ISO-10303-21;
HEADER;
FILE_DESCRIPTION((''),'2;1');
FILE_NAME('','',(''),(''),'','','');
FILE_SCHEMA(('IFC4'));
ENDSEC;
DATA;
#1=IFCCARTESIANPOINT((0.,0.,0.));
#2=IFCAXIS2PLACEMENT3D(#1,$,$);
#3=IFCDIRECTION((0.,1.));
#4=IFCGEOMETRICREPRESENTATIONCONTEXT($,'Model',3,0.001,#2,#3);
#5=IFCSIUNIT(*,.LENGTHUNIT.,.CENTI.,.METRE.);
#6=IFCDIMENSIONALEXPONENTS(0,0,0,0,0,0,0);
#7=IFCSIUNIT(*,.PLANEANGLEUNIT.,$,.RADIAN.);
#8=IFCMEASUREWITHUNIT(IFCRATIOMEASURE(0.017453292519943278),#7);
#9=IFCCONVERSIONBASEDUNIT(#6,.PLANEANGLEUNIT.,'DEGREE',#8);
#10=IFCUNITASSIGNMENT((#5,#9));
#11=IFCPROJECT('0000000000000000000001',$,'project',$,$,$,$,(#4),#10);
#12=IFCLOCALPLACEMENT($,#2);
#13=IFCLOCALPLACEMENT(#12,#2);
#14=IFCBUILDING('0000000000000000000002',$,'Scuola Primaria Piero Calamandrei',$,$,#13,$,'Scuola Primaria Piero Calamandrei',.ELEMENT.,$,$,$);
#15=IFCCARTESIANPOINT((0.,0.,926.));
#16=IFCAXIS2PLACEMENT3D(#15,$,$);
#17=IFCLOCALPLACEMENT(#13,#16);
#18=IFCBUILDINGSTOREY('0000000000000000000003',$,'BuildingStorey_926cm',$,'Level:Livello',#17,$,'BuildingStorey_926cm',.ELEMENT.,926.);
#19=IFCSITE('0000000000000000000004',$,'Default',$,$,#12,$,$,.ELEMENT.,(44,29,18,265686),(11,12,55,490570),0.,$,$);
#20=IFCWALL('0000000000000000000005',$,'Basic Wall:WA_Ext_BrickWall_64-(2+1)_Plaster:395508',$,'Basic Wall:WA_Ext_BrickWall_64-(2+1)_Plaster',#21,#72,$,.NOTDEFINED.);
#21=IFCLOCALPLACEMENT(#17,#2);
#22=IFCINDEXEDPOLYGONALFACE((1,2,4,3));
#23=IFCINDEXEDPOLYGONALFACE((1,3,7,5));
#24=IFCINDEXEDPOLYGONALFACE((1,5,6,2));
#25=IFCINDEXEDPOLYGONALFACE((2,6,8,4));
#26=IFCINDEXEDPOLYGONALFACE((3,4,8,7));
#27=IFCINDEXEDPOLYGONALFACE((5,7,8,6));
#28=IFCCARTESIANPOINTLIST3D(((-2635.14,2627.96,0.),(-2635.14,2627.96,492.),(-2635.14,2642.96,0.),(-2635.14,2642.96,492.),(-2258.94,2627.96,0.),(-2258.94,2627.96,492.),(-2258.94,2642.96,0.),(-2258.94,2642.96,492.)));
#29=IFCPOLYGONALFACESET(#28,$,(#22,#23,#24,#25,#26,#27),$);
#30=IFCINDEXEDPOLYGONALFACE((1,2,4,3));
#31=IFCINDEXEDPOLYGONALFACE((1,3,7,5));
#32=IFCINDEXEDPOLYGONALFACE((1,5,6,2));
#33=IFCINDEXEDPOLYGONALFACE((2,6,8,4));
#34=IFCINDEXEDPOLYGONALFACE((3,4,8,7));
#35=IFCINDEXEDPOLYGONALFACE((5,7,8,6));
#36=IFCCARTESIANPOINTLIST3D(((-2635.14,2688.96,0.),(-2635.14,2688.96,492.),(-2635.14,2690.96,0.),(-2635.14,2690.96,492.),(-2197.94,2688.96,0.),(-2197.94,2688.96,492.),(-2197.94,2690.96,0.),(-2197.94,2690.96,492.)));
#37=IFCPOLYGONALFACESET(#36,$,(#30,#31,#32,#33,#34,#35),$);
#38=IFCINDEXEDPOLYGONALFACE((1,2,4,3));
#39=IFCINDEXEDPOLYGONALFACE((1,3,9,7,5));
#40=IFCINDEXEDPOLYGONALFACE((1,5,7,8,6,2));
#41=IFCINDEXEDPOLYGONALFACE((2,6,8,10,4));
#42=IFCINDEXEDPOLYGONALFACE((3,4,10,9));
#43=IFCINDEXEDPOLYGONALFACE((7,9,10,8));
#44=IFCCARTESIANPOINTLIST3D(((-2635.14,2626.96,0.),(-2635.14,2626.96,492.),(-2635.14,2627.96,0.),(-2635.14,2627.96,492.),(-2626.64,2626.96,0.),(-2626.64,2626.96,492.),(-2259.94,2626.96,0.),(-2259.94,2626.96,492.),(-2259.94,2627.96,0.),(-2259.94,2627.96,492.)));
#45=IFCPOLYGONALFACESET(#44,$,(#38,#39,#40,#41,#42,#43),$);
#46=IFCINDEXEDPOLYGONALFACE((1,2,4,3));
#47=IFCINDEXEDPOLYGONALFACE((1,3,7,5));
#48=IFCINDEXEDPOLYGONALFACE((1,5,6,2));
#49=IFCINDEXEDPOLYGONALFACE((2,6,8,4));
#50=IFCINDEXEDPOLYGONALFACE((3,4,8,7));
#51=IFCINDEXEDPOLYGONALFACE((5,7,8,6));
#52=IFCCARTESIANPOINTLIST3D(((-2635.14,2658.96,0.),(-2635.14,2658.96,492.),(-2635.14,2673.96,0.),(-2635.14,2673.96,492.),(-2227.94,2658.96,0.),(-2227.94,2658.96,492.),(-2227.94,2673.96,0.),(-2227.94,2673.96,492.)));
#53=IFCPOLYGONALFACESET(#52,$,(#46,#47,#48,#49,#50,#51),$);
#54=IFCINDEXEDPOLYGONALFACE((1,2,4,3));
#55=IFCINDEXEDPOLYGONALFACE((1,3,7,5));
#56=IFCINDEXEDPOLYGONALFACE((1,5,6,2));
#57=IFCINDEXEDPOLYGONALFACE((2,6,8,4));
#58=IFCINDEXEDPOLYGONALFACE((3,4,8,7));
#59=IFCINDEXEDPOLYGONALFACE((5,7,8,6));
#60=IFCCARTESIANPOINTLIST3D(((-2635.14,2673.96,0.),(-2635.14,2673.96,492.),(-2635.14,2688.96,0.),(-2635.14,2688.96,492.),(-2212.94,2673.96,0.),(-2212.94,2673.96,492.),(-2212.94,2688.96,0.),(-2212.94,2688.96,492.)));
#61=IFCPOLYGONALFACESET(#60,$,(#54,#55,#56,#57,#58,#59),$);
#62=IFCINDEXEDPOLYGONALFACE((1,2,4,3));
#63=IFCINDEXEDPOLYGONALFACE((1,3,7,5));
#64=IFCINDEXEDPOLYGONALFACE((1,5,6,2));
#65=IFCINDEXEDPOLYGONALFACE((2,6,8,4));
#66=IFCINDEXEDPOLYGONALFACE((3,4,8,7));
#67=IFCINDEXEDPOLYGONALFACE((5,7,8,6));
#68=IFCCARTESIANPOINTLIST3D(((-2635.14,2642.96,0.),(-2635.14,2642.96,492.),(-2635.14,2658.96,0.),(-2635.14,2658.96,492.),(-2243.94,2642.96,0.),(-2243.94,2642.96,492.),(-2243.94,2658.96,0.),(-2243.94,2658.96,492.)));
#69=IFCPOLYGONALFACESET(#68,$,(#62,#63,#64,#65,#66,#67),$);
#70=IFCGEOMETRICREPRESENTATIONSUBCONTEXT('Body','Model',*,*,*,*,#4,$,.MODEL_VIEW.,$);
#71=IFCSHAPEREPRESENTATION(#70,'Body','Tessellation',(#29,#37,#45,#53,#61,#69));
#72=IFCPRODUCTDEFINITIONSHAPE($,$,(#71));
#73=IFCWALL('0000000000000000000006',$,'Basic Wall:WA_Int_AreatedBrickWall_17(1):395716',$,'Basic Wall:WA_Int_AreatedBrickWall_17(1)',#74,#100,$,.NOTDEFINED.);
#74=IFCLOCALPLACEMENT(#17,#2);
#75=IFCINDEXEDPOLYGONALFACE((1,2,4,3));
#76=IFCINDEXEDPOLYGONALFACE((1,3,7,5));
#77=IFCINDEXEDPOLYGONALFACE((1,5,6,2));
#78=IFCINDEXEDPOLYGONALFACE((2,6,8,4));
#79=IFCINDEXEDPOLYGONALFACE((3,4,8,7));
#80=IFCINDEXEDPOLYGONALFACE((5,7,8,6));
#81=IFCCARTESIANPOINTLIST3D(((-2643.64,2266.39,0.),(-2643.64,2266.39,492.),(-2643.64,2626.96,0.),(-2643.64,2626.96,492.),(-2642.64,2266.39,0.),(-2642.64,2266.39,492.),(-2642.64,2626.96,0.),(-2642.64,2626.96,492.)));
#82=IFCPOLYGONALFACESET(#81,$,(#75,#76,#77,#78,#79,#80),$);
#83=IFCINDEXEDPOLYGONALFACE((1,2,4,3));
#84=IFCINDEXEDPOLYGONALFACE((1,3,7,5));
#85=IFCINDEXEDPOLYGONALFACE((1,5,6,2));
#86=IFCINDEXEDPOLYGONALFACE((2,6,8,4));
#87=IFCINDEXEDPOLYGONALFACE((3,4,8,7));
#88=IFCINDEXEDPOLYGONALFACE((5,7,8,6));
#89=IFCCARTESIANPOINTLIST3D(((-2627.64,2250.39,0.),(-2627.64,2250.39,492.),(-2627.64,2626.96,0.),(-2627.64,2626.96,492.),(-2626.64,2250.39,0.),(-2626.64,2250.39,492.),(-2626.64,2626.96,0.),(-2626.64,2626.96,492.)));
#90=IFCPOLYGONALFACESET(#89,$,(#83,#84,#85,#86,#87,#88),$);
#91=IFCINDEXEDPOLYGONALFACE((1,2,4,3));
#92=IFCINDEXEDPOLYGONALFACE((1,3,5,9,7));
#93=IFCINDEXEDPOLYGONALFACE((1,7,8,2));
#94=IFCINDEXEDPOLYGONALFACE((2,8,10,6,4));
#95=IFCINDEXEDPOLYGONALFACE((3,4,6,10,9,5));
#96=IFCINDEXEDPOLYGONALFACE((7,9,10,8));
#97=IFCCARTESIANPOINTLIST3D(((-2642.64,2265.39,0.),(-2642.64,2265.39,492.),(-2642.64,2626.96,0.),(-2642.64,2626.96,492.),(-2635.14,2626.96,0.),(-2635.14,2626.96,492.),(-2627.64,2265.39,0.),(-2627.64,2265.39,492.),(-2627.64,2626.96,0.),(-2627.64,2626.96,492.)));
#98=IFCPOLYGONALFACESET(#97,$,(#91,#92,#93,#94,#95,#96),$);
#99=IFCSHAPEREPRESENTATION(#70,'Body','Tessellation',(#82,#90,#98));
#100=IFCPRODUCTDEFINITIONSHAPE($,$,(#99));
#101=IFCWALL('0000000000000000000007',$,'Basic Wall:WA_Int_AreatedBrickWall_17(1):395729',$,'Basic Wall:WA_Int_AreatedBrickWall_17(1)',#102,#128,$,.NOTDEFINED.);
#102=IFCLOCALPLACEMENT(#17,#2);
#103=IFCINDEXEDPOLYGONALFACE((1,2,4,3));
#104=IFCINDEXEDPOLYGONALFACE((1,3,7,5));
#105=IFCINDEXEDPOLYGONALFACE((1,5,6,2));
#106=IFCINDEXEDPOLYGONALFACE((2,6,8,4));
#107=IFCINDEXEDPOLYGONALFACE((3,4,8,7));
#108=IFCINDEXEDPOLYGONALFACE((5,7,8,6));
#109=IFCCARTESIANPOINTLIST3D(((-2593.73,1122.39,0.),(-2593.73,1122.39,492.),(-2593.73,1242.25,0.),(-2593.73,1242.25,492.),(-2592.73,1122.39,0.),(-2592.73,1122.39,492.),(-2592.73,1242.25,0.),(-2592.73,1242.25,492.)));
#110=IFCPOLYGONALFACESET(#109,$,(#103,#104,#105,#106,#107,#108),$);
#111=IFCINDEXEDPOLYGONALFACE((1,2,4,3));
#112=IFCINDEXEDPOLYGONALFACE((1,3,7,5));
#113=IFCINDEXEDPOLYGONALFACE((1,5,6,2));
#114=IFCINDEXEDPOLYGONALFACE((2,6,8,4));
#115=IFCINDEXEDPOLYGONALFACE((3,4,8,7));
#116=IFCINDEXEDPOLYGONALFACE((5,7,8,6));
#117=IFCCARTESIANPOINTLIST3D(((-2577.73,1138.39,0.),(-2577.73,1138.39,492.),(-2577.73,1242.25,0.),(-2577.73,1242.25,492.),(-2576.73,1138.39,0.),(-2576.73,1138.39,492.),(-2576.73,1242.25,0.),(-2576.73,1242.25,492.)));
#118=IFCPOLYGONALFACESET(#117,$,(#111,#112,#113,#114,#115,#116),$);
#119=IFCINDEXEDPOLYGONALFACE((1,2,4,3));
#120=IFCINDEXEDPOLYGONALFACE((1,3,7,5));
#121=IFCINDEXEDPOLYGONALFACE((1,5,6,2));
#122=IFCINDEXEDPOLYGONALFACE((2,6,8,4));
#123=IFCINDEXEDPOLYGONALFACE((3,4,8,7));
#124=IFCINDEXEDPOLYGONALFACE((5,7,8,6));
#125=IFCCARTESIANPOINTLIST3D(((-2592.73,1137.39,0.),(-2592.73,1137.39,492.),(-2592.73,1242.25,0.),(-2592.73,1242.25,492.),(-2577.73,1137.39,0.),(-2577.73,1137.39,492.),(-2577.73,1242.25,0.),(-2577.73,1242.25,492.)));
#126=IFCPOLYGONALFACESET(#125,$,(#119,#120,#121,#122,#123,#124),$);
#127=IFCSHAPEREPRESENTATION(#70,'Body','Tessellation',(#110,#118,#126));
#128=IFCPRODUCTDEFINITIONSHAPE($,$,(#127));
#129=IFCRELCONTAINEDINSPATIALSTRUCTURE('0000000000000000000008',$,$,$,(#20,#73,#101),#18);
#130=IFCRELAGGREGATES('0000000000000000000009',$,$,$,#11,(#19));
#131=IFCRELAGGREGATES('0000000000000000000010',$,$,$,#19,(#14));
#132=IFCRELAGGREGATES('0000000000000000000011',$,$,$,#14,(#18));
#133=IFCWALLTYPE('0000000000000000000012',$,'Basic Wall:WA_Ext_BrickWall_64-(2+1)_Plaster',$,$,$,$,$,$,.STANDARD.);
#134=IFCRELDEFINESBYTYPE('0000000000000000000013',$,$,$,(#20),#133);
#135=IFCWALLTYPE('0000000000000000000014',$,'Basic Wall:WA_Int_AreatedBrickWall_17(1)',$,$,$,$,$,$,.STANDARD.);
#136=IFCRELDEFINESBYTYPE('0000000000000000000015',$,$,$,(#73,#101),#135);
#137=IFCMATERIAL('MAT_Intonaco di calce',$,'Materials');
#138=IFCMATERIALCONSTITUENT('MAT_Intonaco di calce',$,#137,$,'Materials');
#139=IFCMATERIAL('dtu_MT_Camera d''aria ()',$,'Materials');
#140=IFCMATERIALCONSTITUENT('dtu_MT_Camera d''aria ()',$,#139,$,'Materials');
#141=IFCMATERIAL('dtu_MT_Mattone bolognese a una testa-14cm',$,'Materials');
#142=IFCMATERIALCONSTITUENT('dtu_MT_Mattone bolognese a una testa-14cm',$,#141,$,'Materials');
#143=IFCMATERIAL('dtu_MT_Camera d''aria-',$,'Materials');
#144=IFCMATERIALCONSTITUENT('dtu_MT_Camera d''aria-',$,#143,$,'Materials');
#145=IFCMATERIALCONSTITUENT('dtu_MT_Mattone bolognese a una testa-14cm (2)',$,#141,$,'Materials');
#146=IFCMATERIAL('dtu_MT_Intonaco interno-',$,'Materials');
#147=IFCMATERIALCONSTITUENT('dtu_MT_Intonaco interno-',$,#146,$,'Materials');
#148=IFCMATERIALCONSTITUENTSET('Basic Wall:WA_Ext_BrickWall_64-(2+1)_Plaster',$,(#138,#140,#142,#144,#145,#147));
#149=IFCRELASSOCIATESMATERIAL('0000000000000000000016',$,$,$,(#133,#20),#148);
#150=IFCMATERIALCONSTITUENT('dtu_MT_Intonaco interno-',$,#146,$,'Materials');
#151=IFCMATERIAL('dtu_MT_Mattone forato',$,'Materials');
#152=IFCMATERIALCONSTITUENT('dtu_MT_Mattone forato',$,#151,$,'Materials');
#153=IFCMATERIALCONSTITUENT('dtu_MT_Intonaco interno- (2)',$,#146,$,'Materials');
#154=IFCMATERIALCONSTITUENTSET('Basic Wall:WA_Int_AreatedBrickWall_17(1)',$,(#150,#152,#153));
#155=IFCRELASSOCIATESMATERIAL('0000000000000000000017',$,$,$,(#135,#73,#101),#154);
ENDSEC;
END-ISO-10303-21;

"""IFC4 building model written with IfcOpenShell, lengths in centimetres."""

from ifc_helpers import new_model, entity, si_unit, converted_unit, direction, frame, origin, place, context, subcontext, project, spatial, indexed_curve, outline, extrude, material, constituent, constituent_set, type_object, element, save


model = new_model("IFC4")

# Units and contexts
model_context = context("Model", 3, precision=0.001, world=origin(), true_north=direction((0.0, 1.0)))
body_context = subcontext(model_context, "Body", "Model", "MODEL_VIEW")
ifc_project = project(units=[si_unit("LENGTHUNIT", "METRE", prefix="CENTI"), converted_unit("PLANEANGLEUNIT", "DEGREE", entity("IfcRatioMeasure", 0.017453292519943278), si_unit("PLANEANGLEUNIT", "RADIAN"), dimensions=[0, 0, 0, 0, 0, 0, 0])], contexts=[model_context])

# Site, building, storey
site_placement = place(None, origin())
site = spatial("IfcSite", under=ifc_project, at=site_placement, Name="Default", CompositionType="ELEMENT", RefLatitude=(44, 29, 18, 265686), RefLongitude=(11, 12, 55, 490570), RefElevation=0.0)
building_placement = place(site_placement, origin())
building = spatial("IfcBuilding", under=site, at=building_placement, Name="Scuola Primaria Piero Calamandrei", LongName="Scuola Primaria Piero Calamandrei", CompositionType="ELEMENT")
storey_placement = place(building_placement, frame((0.0, 0.0, 926.0)))
storey = spatial("IfcBuildingStorey", under=building, at=storey_placement, Name="BuildingStorey_926cm", ObjectType="Level:Livello", LongName="BuildingStorey_926cm", CompositionType="ELEMENT", Elevation=926.0)

# Wall
ifc_material_1 = material(Name="MAT_Intonaco di calce", Category="Materials")
ifc_constituent_1 = constituent(ifc_material_1, Name="MAT_Intonaco di calce", Category="Materials")
ifc_material_2 = material(Name="dtu_MT_Camera d'aria ()", Category="Materials")
ifc_constituent_2 = constituent(ifc_material_2, Name="dtu_MT_Camera d'aria ()", Category="Materials")
ifc_material_3 = material(Name="dtu_MT_Mattone bolognese a una testa-14cm", Category="Materials")
ifc_constituent_3 = constituent(ifc_material_3, Name="dtu_MT_Mattone bolognese a una testa-14cm", Category="Materials")
ifc_material_4 = material(Name="dtu_MT_Camera d'aria-", Category="Materials")
ifc_constituent_4 = constituent(ifc_material_4, Name="dtu_MT_Camera d'aria-", Category="Materials")
ifc_constituent_5 = constituent(ifc_material_3, Name="dtu_MT_Mattone bolognese a una testa-14cm (2)", Category="Materials")
ifc_material_5 = material(Name="dtu_MT_Intonaco interno-", Category="Materials")
ifc_constituent_6 = constituent(ifc_material_5, Name="dtu_MT_Intonaco interno-", Category="Materials")
ifc_constituent_set_1 = constituent_set(constituents=[ifc_constituent_1, ifc_constituent_2, ifc_constituent_3, ifc_constituent_4, ifc_constituent_5, ifc_constituent_6], Name="Basic Wall:WA_Ext_BrickWall_64-(2+1)_Plaster")
wall_type_1 = type_object("IfcWallType", Name="Basic Wall:WA_Ext_BrickWall_64-(2+1)_Plaster", PredefinedType="STANDARD", material=ifc_constituent_set_1)
wall_1_placement = place(storey_placement, frame((-2635.14, 2658.96, 0.0)))
element("IfcWall", 1, at=wall_1_placement, inside=storey, type_object=wall_type_1, material=ifc_constituent_set_1, Name="Basic Wall:WA_Ext_BrickWall_64-(2+1)_Plaster:395508", ObjectType="Basic Wall:WA_Ext_BrickWall_64-(2+1)_Plaster", PredefinedType="NOTDEFINED", context=body_context, shape_type="SweptSolid", body=[
    extrude(outline(indexed_curve([(-188.1, -7.5), (188.1, -7.5), (188.1, 7.5), (-188.1, 7.5), (-188.1, -7.5)], self_intersect=False)), frame((188.1, -23.5, 0.0)), (0.0, 0.0, 1.0), 492.0),
    extrude(outline(indexed_curve([(-1.0, -218.6), (1.0, -218.6), (1.0, 218.6), (-1.0, 218.6), (-1.0, -218.6)], self_intersect=False)), frame((218.6, 31.0, 0.0), z_axis=(0.0, 0.0, 1.0), x_axis=(0.0, -1.0, 0.0)), (0.0, 0.0, 1.0), 492.0),
    extrude(outline(indexed_curve([(-143.28, -0.4), (223.42, -0.4), (223.42, 0.6), (-151.78, 0.6), (-151.78, -0.4), (-143.28, -0.4)], self_intersect=False)), frame((151.78, -31.6, 0.0)), (0.0, 0.0, 1.0), 492.0),
    extrude(outline(indexed_curve([(-203.6, -7.5), (203.6, -7.5), (203.6, 7.5), (-203.6, 7.5), (-203.6, -7.5)], self_intersect=False)), frame((203.6, 7.5, 0.0)), (0.0, 0.0, 1.0), 492.0),
    extrude(outline(indexed_curve([(-211.1, -7.5), (211.1, -7.5), (211.1, 7.5), (-211.1, 7.5), (-211.1, -7.5)], self_intersect=False)), frame((211.1, 22.5, 0.0)), (0.0, 0.0, 1.0), 492.0),
    extrude(outline(indexed_curve([(-195.6, -8.0), (195.6, -8.0), (195.6, 8.0), (-195.6, 8.0), (-195.6, -8.0)], self_intersect=False)), frame((195.6, -8.0, 0.0)), (0.0, 0.0, 1.0), 492.0),
])

# Shared definitions
ifc_constituent_7 = constituent(ifc_material_5, Name="dtu_MT_Intonaco interno-", Category="Materials")
ifc_material_6 = material(Name="dtu_MT_Mattone forato", Category="Materials")
ifc_constituent_8 = constituent(ifc_material_6, Name="dtu_MT_Mattone forato", Category="Materials")
ifc_constituent_9 = constituent(ifc_material_5, Name="dtu_MT_Intonaco interno- (2)", Category="Materials")
ifc_constituent_set_2 = constituent_set(constituents=[ifc_constituent_7, ifc_constituent_8, ifc_constituent_9], Name="Basic Wall:WA_Int_AreatedBrickWall_17(1)")
wall_type_2 = type_object("IfcWallType", Name="Basic Wall:WA_Int_AreatedBrickWall_17(1)", PredefinedType="STANDARD", material=ifc_constituent_set_2)

# Wall
wall_2_placement = place(storey_placement, frame((-2635.14, 2626.96, 0.0), z_axis=(0.0, 0.0, 1.0), x_axis=(0.0, -1.0, 0.0)))
element("IfcWall", 2, at=wall_2_placement, inside=storey, type_object=wall_type_2, material=ifc_constituent_set_2, Name="Basic Wall:WA_Int_AreatedBrickWall_17(1):395716", ObjectType="Basic Wall:WA_Int_AreatedBrickWall_17(1)", PredefinedType="NOTDEFINED", context=body_context, shape_type="SweptSolid", body=[
    extrude(outline(indexed_curve([(-0.5, -180.29), (0.5, -180.29), (0.5, 180.29), (-0.5, 180.29), (-0.5, -180.29)], self_intersect=False)), frame((180.29, -8.0, 0.0), z_axis=(0.0, 0.0, 1.0), x_axis=(0.0, 1.0, 0.0)), (0.0, 0.0, 1.0), 492.0),
    extrude(outline(indexed_curve([(-0.5, -188.29), (0.5, -188.29), (0.5, 188.29), (-0.5, 188.29), (-0.5, -188.29)], self_intersect=False)), frame((188.29, 8.0, 0.0), z_axis=(0.0, 0.0, 1.0), x_axis=(0.0, -1.0, 0.0)), (0.0, 0.0, 1.0), 492.0),
    extrude(outline(indexed_curve([(-144.63, -7.5), (216.94, -7.5), (216.94, 7.5), (-144.63, 7.5), (-144.63, 0.0), (-144.63, -7.5)], self_intersect=False)), frame((144.63, 0.0, 0.0)), (0.0, 0.0, 1.0), 492.0),
])

# Wall
wall_3_placement = place(storey_placement, frame((-2585.23, 1242.25, 0.0), z_axis=(0.0, 0.0, 1.0), x_axis=(0.0, -1.0, 0.0)))
element("IfcWall", 3, at=wall_3_placement, inside=storey, type_object=wall_type_2, material=ifc_constituent_set_2, Name="Basic Wall:WA_Int_AreatedBrickWall_17(1):395729", ObjectType="Basic Wall:WA_Int_AreatedBrickWall_17(1)", PredefinedType="NOTDEFINED", context=body_context, shape_type="SweptSolid", body=[
    extrude(outline(indexed_curve([(-0.5, -59.93), (0.5, -59.93), (0.5, 59.93), (-0.5, 59.93), (-0.5, -59.93)], self_intersect=False)), frame((59.93, -8.0, 0.0), z_axis=(0.0, 0.0, 1.0), x_axis=(0.0, 1.0, 0.0)), (0.0, 0.0, 1.0), 492.0),
    extrude(outline(indexed_curve([(-0.5, -51.93), (0.5, -51.93), (0.5, 51.93), (-0.5, 51.93), (-0.5, -51.93)], self_intersect=False)), frame((51.93, 8.0, 0.0), z_axis=(0.0, 0.0, 1.0), x_axis=(0.0, -1.0, 0.0)), (0.0, 0.0, 1.0), 492.0),
    extrude(outline(indexed_curve([(-52.43, -7.5), (52.43, -7.5), (52.43, 7.5), (-52.43, 7.5), (-52.43, -7.5)], self_intersect=False)), frame((52.43, 0.0, 0.0)), (0.0, 0.0, 1.0), 492.0),
])

save(model, "model.ifc")
